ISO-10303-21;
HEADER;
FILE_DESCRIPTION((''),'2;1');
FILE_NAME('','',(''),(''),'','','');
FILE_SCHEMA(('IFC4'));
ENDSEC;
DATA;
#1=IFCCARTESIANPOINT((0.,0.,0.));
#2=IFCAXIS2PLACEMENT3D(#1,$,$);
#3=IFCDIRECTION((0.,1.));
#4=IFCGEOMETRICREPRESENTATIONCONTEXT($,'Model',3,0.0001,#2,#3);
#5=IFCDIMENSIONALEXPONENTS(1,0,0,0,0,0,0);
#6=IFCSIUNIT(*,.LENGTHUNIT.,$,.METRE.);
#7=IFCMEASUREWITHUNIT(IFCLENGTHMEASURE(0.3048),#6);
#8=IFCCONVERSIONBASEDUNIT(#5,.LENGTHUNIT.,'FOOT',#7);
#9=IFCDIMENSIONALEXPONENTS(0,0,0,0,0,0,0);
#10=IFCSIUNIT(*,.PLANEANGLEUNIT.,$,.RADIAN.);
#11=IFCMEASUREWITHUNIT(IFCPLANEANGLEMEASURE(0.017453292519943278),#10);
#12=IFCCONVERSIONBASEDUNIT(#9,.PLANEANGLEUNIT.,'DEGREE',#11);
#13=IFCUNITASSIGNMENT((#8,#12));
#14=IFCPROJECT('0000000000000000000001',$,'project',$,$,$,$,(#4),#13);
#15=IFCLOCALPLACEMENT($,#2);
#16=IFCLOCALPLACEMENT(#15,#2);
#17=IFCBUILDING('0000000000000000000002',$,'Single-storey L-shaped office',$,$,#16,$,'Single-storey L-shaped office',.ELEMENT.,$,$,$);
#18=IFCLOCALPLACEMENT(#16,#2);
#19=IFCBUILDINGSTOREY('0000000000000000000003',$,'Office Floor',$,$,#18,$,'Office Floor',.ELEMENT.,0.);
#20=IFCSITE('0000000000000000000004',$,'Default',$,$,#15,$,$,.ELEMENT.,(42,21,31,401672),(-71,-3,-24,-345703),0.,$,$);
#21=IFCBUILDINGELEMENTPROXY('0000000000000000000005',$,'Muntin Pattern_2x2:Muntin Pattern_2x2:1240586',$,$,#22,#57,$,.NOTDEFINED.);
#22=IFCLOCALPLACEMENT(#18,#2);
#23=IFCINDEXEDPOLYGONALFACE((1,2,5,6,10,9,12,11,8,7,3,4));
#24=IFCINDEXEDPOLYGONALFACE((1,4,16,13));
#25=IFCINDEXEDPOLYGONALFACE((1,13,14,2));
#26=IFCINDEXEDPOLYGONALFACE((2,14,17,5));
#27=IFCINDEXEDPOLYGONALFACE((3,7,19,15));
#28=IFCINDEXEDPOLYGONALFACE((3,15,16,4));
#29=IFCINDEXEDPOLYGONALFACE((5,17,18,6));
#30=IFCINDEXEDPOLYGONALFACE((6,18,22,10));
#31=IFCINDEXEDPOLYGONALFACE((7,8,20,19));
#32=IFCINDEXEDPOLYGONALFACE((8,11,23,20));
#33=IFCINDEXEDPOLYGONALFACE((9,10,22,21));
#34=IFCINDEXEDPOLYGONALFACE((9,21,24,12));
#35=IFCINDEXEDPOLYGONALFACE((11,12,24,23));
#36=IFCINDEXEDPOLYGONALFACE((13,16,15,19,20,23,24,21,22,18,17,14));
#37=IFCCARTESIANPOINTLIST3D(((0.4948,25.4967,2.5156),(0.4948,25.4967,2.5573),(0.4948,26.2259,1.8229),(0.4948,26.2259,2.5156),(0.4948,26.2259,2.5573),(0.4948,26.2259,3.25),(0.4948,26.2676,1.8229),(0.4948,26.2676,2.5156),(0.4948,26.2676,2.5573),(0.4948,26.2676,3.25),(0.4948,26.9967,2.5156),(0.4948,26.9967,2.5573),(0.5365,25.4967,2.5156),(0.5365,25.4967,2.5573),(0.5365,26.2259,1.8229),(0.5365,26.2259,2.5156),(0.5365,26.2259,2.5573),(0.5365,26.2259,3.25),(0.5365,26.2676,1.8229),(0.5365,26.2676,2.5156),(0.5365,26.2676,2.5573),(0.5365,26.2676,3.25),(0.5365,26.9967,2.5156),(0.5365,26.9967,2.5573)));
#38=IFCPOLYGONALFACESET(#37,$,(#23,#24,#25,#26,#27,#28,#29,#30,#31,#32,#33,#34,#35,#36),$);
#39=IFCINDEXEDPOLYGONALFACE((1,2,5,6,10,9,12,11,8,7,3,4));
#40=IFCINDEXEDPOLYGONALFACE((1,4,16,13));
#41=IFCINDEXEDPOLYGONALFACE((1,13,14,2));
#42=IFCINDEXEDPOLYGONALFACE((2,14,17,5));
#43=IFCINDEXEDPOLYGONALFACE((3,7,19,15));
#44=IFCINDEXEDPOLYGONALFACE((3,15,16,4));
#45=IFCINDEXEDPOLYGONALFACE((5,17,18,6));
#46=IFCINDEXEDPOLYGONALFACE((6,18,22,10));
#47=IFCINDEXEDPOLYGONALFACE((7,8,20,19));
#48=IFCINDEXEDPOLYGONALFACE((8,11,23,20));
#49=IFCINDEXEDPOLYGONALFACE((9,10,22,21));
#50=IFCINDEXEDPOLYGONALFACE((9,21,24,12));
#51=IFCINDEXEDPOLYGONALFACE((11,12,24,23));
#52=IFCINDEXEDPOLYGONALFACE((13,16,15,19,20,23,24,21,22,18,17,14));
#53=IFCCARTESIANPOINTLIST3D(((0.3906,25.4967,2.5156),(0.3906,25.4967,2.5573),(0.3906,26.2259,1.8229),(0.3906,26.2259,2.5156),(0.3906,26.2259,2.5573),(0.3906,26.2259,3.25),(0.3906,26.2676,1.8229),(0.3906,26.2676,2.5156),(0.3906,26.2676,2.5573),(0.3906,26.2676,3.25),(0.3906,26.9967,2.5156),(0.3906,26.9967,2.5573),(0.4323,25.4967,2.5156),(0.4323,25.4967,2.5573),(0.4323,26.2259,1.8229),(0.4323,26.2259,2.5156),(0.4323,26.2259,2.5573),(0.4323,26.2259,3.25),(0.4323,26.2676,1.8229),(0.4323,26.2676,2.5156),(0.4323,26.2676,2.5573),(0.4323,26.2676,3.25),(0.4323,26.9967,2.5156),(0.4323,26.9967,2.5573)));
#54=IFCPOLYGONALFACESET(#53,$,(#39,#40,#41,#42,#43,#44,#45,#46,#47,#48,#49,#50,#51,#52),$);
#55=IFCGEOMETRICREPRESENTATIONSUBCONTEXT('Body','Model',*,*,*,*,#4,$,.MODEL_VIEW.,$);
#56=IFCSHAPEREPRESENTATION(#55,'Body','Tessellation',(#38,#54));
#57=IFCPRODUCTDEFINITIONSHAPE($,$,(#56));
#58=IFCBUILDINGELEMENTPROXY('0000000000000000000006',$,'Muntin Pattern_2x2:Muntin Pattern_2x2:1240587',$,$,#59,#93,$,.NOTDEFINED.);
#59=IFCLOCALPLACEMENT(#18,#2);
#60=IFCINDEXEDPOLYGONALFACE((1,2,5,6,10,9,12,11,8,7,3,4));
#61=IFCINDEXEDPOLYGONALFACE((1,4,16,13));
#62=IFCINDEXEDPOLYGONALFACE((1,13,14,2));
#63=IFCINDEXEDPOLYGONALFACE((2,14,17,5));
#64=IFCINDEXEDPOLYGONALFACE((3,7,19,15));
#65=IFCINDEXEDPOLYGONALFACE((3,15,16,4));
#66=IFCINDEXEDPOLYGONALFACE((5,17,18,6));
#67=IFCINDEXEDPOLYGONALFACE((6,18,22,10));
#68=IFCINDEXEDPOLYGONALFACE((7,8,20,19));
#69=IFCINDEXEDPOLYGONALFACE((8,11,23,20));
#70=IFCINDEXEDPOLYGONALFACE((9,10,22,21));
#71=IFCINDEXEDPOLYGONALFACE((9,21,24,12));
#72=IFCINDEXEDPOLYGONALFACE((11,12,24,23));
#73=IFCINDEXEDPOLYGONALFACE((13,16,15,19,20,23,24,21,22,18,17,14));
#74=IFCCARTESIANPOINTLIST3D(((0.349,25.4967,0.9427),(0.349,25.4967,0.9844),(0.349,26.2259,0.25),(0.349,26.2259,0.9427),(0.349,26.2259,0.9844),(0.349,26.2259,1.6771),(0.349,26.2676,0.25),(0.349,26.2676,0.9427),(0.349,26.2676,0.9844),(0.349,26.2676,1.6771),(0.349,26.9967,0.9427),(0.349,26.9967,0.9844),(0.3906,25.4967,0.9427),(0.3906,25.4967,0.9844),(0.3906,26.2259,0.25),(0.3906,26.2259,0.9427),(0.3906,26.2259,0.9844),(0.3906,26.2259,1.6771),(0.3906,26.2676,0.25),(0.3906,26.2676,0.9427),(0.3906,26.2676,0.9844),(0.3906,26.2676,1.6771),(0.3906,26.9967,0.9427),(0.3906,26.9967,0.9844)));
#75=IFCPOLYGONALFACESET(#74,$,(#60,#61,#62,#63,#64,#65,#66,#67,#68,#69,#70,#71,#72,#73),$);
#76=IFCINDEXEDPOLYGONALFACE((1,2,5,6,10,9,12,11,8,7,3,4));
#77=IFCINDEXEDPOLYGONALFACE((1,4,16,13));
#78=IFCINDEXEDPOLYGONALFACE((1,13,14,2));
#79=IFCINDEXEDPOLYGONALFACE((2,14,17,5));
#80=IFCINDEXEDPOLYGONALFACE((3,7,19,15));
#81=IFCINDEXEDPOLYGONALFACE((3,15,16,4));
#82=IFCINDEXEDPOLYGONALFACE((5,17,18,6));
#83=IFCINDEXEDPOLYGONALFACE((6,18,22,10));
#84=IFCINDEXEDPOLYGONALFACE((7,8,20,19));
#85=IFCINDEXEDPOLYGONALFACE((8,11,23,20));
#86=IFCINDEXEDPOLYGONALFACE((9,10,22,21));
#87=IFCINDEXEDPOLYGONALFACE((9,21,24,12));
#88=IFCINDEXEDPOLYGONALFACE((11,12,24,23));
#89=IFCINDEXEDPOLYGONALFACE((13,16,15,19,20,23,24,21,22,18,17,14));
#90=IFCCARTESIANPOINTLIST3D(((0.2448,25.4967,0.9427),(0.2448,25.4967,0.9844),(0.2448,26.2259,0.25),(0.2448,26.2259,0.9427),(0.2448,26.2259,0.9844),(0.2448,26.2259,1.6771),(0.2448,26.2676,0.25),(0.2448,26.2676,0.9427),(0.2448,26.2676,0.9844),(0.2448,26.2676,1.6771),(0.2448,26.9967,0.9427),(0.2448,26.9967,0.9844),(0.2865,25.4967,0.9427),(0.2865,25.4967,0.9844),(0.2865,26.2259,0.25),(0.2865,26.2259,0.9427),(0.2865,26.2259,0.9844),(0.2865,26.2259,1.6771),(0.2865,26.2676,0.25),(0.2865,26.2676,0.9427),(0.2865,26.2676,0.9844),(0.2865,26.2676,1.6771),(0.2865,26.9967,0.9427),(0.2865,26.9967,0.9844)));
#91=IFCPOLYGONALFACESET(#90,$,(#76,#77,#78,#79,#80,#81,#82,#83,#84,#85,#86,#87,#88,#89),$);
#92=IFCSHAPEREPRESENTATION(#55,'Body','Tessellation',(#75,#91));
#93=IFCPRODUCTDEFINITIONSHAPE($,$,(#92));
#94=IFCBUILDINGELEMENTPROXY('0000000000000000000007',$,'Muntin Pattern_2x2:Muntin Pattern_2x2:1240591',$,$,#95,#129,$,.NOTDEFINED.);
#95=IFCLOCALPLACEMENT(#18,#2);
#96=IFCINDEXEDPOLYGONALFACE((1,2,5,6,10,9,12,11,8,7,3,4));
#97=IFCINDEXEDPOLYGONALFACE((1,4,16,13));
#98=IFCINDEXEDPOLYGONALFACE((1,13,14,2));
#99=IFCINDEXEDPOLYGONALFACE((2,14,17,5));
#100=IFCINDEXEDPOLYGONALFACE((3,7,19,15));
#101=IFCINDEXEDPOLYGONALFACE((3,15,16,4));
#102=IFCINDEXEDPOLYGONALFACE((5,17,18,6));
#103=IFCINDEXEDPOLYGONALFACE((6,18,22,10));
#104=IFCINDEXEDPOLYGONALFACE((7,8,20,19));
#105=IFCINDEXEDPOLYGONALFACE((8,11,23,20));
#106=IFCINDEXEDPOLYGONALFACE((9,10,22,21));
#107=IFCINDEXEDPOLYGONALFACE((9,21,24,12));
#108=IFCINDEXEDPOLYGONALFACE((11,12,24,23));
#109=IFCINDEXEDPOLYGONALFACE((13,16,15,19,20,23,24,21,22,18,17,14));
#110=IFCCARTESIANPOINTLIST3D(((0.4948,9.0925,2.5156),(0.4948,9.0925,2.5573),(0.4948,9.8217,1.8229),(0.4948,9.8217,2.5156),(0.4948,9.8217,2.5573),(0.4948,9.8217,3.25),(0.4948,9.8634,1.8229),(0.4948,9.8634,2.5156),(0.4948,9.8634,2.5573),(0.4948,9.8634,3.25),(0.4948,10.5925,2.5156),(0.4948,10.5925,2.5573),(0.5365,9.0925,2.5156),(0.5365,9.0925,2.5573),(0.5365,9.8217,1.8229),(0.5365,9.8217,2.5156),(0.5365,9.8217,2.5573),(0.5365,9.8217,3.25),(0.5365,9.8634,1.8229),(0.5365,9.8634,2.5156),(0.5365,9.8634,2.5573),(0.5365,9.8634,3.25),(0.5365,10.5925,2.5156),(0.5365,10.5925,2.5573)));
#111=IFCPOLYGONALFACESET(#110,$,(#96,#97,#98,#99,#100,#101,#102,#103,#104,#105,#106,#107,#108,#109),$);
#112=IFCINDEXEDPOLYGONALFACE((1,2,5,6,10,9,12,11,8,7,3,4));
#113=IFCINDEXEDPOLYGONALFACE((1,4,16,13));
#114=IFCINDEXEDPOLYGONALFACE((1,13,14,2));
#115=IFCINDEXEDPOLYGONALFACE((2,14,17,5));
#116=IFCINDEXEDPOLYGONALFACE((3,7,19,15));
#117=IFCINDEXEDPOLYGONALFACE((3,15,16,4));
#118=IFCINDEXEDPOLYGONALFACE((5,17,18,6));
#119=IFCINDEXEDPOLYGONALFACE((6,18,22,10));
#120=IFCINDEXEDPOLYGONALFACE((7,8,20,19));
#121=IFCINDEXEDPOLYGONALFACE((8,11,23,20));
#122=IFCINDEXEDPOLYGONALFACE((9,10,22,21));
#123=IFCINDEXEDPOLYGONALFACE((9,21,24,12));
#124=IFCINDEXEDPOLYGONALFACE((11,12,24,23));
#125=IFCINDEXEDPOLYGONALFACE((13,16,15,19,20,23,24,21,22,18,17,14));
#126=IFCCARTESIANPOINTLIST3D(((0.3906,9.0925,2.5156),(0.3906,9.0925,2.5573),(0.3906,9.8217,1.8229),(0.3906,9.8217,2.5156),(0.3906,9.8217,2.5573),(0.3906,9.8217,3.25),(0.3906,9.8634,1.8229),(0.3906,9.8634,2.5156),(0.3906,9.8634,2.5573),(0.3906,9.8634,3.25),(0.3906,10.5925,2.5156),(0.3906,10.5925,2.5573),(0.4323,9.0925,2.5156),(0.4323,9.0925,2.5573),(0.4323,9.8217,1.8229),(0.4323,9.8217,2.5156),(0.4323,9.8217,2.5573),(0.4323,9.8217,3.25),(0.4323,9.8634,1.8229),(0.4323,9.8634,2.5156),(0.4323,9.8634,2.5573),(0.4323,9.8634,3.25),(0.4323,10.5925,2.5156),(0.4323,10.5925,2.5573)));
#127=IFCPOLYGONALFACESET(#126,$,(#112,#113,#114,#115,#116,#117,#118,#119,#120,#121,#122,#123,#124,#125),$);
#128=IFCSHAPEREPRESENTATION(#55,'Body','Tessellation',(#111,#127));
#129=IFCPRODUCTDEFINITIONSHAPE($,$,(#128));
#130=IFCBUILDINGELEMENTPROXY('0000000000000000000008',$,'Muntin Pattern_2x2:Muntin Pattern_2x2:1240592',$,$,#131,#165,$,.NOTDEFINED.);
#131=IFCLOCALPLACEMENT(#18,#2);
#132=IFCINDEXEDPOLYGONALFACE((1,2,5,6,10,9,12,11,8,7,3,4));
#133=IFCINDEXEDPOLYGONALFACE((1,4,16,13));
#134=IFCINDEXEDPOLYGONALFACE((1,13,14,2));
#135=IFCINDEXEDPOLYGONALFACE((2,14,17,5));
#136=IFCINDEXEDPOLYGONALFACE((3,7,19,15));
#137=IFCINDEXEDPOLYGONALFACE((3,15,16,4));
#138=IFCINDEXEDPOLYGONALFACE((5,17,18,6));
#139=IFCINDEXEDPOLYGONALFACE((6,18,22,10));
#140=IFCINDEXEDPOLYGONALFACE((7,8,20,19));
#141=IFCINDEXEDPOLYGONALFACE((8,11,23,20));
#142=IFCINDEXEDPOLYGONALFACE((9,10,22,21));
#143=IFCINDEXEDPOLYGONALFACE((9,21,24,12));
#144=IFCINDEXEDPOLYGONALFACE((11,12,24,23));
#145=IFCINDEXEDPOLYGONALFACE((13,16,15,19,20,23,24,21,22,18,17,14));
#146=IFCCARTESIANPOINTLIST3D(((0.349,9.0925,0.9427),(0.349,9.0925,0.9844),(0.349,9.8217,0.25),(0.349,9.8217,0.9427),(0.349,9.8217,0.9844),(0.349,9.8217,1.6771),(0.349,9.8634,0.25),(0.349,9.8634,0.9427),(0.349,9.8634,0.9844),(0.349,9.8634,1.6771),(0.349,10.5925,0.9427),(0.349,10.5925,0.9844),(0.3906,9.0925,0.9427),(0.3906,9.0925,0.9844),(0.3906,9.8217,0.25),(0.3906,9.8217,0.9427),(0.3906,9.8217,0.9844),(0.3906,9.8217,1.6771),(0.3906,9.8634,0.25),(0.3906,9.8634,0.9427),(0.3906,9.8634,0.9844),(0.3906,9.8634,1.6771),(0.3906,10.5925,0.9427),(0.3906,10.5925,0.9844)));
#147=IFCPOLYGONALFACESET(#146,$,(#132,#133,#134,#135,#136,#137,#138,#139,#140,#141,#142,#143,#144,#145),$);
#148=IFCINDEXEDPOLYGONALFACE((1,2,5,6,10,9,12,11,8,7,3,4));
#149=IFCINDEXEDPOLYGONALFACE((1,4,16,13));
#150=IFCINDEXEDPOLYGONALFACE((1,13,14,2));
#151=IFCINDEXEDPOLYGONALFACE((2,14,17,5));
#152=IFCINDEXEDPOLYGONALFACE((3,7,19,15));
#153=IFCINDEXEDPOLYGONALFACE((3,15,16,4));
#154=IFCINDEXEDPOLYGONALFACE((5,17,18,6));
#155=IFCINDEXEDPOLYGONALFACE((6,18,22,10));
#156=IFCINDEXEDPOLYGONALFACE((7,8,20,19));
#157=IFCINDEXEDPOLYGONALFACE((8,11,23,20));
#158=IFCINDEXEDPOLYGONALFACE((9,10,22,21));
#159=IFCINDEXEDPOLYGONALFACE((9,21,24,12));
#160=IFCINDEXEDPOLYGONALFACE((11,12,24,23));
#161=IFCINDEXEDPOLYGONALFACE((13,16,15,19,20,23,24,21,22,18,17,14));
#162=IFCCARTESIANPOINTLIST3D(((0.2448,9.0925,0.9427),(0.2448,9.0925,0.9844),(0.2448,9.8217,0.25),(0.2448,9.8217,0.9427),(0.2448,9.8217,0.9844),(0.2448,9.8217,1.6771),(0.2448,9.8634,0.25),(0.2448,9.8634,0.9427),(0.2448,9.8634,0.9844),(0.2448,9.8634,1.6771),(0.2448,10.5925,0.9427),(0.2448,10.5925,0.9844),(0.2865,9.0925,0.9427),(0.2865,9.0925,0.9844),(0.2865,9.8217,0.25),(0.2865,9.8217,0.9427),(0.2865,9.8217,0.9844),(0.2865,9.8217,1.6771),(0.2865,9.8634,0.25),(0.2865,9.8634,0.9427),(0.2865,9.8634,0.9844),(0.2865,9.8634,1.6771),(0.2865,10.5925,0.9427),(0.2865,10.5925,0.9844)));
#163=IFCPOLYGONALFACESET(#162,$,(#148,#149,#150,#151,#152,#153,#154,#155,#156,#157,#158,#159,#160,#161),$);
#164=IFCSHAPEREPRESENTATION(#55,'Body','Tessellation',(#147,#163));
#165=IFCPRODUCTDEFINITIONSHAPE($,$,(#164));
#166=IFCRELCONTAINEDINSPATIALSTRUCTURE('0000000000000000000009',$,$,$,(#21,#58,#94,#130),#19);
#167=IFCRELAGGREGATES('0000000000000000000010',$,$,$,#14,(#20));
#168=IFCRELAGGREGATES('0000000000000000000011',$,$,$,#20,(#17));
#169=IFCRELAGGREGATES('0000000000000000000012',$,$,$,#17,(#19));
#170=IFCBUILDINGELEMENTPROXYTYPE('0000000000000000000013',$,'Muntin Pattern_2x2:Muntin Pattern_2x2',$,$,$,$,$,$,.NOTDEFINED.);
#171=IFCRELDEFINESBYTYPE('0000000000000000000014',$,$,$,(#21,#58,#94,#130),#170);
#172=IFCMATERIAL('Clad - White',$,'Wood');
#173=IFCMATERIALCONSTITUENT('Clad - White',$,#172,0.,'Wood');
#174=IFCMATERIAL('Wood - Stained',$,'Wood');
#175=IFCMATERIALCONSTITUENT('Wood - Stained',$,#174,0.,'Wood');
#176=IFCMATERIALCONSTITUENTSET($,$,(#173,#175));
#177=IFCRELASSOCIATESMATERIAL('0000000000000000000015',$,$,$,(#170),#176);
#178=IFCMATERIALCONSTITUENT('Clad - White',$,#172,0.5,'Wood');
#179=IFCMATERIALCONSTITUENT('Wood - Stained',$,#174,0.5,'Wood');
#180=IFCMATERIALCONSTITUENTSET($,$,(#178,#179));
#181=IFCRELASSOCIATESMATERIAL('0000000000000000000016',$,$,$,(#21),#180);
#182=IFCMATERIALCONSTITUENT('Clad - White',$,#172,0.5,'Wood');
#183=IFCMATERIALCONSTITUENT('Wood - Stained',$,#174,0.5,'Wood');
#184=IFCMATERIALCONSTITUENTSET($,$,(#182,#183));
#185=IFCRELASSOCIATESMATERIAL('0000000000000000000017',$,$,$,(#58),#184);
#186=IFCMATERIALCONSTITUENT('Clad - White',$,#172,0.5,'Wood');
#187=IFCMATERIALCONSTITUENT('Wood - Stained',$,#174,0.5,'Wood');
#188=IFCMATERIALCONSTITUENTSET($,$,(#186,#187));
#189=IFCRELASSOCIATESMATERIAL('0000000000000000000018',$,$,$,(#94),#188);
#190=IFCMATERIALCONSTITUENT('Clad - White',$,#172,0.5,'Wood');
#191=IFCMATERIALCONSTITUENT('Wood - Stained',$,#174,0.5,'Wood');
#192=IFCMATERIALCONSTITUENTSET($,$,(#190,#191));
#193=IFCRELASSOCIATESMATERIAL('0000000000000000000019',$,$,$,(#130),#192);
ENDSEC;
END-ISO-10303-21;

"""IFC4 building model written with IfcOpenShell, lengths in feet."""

from ifc_helpers import new_model, entity, si_unit, converted_unit, direction, frame, origin, place, context, subcontext, project, spatial, indexed_curve, outline, extrude, source, transform, mapped, material, constituent, constituent_set, type_object, type_shapes, element, save


model = new_model("IFC4")

# Units and contexts
model_context = context("Model", 3, precision=0.0001, world=origin(), true_north=direction((0.0, 1.0)))
body_context = subcontext(model_context, "Body", "Model", "MODEL_VIEW")
ifc_project = project(units=[converted_unit("LENGTHUNIT", "FOOT", entity("IfcLengthMeasure", 0.3048), si_unit("LENGTHUNIT", "METRE"), dimensions=[1, 0, 0, 0, 0, 0, 0]), converted_unit("PLANEANGLEUNIT", "DEGREE", entity("IfcPlaneAngleMeasure", 0.017453292519943278), si_unit("PLANEANGLEUNIT", "RADIAN"), dimensions=[0, 0, 0, 0, 0, 0, 0])], contexts=[model_context])

# Site, building, storey
site_placement = place(None, origin())
site = spatial("IfcSite", under=ifc_project, at=site_placement, Name="Default", CompositionType="ELEMENT", RefLatitude=(42, 21, 31, 401672), RefLongitude=(-71, -3, -24, -345703), RefElevation=0.0)
building_placement = place(site_placement, origin())
building = spatial("IfcBuilding", under=site, at=building_placement, Name="Single-storey L-shaped office", LongName="Single-storey L-shaped office", CompositionType="ELEMENT")
storey_placement = place(building_placement, origin())
storey = spatial("IfcBuildingStorey", under=building, at=storey_placement, Name="Office Floor", LongName="Office Floor", CompositionType="ELEMENT", Elevation=0.0)

# Shared definitions
ifc_material_1 = material(Name="Wood - Stained", Category="Wood")

# Building element proxies
ifc_material_2 = material(Name="Clad - White", Category="Wood")
ifc_constituent_1 = constituent(ifc_material_2, Name="Clad - White", Category="Wood", fraction=0.0)
ifc_constituent_2 = constituent(ifc_material_1, Name="Wood - Stained", Category="Wood", fraction=0.0)
ifc_constituent_set_1 = constituent_set(constituents=[ifc_constituent_1, ifc_constituent_2])
building_element_proxy_type_1 = type_object("IfcBuildingElementProxyType", Name="Muntin Pattern_2x2:Muntin Pattern_2x2", PredefinedType="NOTDEFINED", material=ifc_constituent_set_1)
shared_shape_1 = source(origin(), body_context, "Body", "SweptSolid", [
    extrude(outline(indexed_curve([(0.0208, -0.0208), (0.7135, -0.0208), (0.7135, 0.0208), (0.0208, 0.0208), (0.0208, 0.75), (-0.0208, 0.75), (-0.0208, 0.0208), (-0.7135, 0.0208), (-0.7135, -0.0208), (-0.0208, -0.0208), (-0.0208, -0.75), (0.0208, -0.75), (0.0208, -0.0208)], self_intersect=False)), frame((0.0, 0.0312, 0.7135), z_axis=(0.0, 1.0, 0.0), x_axis=(0.0, 0.0, 1.0)), (0.0, 0.0, 1.0), 0.0417),
    extrude(outline(indexed_curve([(0.0208, -0.0208), (0.7135, -0.0208), (0.7135, 0.0208), (0.0208, 0.0208), (0.0208, 0.75), (-0.0208, 0.75), (-0.0208, 0.0208), (-0.7135, 0.0208), (-0.7135, -0.0208), (-0.0208, -0.0208), (-0.0208, -0.75), (0.0208, -0.75), (0.0208, -0.0208)], self_intersect=False)), frame((0.0, -0.0729, 0.7135), z_axis=(0.0, 1.0, 0.0), x_axis=(0.0, 0.0, 1.0)), (0.0, 0.0, 1.0), 0.0417),
])
type_shapes(building_element_proxy_type_1, [shared_shape_1])
ifc_constituent_3 = constituent(ifc_material_2, Name="Clad - White", Category="Wood", fraction=0.5)
ifc_constituent_4 = constituent(ifc_material_1, Name="Wood - Stained", Category="Wood", fraction=0.5)
ifc_constituent_set_2 = constituent_set(constituents=[ifc_constituent_3, ifc_constituent_4])
proxy_1_placement = place(storey_placement, frame((0.4635, 26.2467, 1.8229), z_axis=(0.0, 0.0, 1.0), x_axis=(0.0, -1.0, 0.0)))
element("IfcBuildingElementProxy", 1, at=proxy_1_placement, inside=storey, type_object=building_element_proxy_type_1, material=ifc_constituent_set_2, Name="Muntin Pattern_2x2:Muntin Pattern_2x2:1240586", PredefinedType="NOTDEFINED", context=body_context, shape_type="MappedRepresentation", body=[
    mapped(shared_shape_1, transform((0.0, 0.0, 0.0), scale=1.0)),
])
ifc_constituent_5 = constituent(ifc_material_2, Name="Clad - White", Category="Wood", fraction=0.5)
ifc_constituent_6 = constituent(ifc_material_1, Name="Wood - Stained", Category="Wood", fraction=0.5)
ifc_constituent_set_3 = constituent_set(constituents=[ifc_constituent_5, ifc_constituent_6])
proxy_2_placement = place(storey_placement, frame((0.3177, 26.2467, 0.25), z_axis=(0.0, 0.0, 1.0), x_axis=(0.0, -1.0, 0.0)))
element("IfcBuildingElementProxy", 2, at=proxy_2_placement, inside=storey, type_object=building_element_proxy_type_1, material=ifc_constituent_set_3, Name="Muntin Pattern_2x2:Muntin Pattern_2x2:1240587", PredefinedType="NOTDEFINED", context=body_context, shape_type="MappedRepresentation", body=[
    mapped(shared_shape_1, transform((0.0, 0.0, 0.0), scale=1.0)),
])
ifc_constituent_7 = constituent(ifc_material_2, Name="Clad - White", Category="Wood", fraction=0.5)
ifc_constituent_8 = constituent(ifc_material_1, Name="Wood - Stained", Category="Wood", fraction=0.5)
ifc_constituent_set_4 = constituent_set(constituents=[ifc_constituent_7, ifc_constituent_8])
proxy_3_placement = place(storey_placement, frame((0.4635, 9.8425, 1.8229), z_axis=(0.0, 0.0, 1.0), x_axis=(0.0, -1.0, 0.0)))
element("IfcBuildingElementProxy", 3, at=proxy_3_placement, inside=storey, type_object=building_element_proxy_type_1, material=ifc_constituent_set_4, Name="Muntin Pattern_2x2:Muntin Pattern_2x2:1240591", PredefinedType="NOTDEFINED", context=body_context, shape_type="MappedRepresentation", body=[
    mapped(shared_shape_1, transform((0.0, 0.0, 0.0), scale=1.0)),
])
ifc_constituent_9 = constituent(ifc_material_2, Name="Clad - White", Category="Wood", fraction=0.5)
ifc_constituent_10 = constituent(ifc_material_1, Name="Wood - Stained", Category="Wood", fraction=0.5)
ifc_constituent_set_5 = constituent_set(constituents=[ifc_constituent_9, ifc_constituent_10])
proxy_4_placement = place(storey_placement, frame((0.3177, 9.8425, 0.25), z_axis=(0.0, 0.0, 1.0), x_axis=(0.0, -1.0, 0.0)))
element("IfcBuildingElementProxy", 4, at=proxy_4_placement, inside=storey, type_object=building_element_proxy_type_1, material=ifc_constituent_set_5, Name="Muntin Pattern_2x2:Muntin Pattern_2x2:1240592", PredefinedType="NOTDEFINED", context=body_context, shape_type="MappedRepresentation", body=[
    mapped(shared_shape_1, transform((0.0, 0.0, 0.0), scale=1.0)),
])

save(model, "model.ifc")
